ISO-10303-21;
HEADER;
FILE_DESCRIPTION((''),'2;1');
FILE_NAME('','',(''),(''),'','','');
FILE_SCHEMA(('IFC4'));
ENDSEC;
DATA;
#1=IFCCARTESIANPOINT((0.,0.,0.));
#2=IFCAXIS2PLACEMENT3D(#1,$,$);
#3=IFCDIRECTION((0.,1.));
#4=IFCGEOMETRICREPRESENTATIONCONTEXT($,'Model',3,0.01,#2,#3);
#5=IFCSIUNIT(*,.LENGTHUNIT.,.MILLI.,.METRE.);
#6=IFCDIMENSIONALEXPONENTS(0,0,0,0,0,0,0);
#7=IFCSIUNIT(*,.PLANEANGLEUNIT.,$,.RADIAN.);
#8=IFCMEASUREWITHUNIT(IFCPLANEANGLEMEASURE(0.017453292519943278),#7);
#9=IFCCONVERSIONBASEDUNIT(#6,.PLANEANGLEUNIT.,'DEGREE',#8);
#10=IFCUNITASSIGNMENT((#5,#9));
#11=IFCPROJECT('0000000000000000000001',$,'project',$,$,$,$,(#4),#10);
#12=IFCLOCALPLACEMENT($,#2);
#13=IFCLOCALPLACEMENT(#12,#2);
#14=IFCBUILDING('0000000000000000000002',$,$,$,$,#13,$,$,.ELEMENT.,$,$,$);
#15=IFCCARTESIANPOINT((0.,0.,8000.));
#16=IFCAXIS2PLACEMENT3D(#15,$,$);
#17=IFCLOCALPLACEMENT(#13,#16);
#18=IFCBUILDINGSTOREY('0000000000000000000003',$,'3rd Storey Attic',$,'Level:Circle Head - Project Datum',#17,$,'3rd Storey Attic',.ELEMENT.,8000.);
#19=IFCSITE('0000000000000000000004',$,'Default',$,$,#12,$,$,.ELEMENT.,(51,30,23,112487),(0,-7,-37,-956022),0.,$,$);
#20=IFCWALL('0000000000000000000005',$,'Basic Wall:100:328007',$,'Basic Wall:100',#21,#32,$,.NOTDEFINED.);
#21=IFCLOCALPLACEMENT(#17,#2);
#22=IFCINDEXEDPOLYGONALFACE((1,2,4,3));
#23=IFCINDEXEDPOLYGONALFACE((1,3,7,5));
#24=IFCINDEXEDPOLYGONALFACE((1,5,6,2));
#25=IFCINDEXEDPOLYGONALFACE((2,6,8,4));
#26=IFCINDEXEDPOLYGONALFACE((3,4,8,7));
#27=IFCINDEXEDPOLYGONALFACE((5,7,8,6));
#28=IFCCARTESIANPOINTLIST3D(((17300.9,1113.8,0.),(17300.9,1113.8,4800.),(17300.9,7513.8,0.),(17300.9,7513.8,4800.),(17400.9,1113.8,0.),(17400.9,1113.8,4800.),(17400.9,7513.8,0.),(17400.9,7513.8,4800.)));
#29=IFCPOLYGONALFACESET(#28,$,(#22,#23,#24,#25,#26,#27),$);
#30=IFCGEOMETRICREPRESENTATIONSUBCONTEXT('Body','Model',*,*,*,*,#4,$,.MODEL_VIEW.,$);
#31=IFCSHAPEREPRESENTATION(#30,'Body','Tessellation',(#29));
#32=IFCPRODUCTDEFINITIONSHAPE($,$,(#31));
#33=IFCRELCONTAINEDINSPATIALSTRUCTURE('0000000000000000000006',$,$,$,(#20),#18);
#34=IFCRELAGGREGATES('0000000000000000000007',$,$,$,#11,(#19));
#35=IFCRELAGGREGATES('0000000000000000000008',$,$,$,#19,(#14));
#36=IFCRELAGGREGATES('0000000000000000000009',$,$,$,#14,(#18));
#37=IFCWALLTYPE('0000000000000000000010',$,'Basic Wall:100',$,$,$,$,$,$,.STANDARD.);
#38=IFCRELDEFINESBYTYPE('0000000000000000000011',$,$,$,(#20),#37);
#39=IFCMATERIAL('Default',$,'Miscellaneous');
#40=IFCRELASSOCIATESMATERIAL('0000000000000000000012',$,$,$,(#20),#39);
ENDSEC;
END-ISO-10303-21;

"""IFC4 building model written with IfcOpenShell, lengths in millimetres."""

from ifc_helpers import new_model, entity, si_unit, converted_unit, direction, frame, origin, place, context, subcontext, project, spatial, indexed_curve, outline, extrude, material, type_object, element, save


model = new_model("IFC4")

# Units and contexts
model_context = context("Model", 3, precision=0.01, world=origin(), true_north=direction((0.0, 1.0)))
body_context = subcontext(model_context, "Body", "Model", "MODEL_VIEW")
ifc_project = project(units=[si_unit("LENGTHUNIT", "METRE", prefix="MILLI"), converted_unit("PLANEANGLEUNIT", "DEGREE", entity("IfcPlaneAngleMeasure", 0.017453292519943278), si_unit("PLANEANGLEUNIT", "RADIAN"), dimensions=[0, 0, 0, 0, 0, 0, 0])], contexts=[model_context])

# Site, building, storey
site_placement = place(None, origin())
site = spatial("IfcSite", under=ifc_project, at=site_placement, Name="Default", CompositionType="ELEMENT", RefLatitude=(51, 30, 23, 112487), RefLongitude=(0, -7, -37, -956022), RefElevation=0.0)
building_placement = place(site_placement, origin())
building = spatial("IfcBuilding", under=site, at=building_placement, CompositionType="ELEMENT")
storey_placement = place(building_placement, frame((0.0, 0.0, 8000.0)))
storey = spatial("IfcBuildingStorey", under=building, at=storey_placement, Name="3rd Storey Attic", ObjectType="Level:Circle Head - Project Datum", LongName="3rd Storey Attic", CompositionType="ELEMENT", Elevation=8000.0)

# Shared definitions
ifc_material_1 = material(Name="Default", Category="Miscellaneous")

# Wall
wall_type = type_object("IfcWallType", Name="Basic Wall:100", PredefinedType="STANDARD")
wall_placement = place(storey_placement, frame((17350.9, 1113.8, 0.0), z_axis=(0.0, 0.0, 1.0), x_axis=(0.0, 1.0, 0.0)))
element("IfcWall", 1, at=wall_placement, inside=storey, type_object=wall_type, material=ifc_material_1, Name="Basic Wall:100:328007", ObjectType="Basic Wall:100", PredefinedType="NOTDEFINED", context=body_context, shape_type="SweptSolid", body=[
    extrude(outline(indexed_curve([(6400.0, 50.0), (0.0, 50.0), (0.0, -50.0), (6400.0, -50.0), (6400.0, 50.0)], self_intersect=False)), origin(), (0.0, 0.0, 1.0), 4800.0),
])

save(model, "model.ifc")
